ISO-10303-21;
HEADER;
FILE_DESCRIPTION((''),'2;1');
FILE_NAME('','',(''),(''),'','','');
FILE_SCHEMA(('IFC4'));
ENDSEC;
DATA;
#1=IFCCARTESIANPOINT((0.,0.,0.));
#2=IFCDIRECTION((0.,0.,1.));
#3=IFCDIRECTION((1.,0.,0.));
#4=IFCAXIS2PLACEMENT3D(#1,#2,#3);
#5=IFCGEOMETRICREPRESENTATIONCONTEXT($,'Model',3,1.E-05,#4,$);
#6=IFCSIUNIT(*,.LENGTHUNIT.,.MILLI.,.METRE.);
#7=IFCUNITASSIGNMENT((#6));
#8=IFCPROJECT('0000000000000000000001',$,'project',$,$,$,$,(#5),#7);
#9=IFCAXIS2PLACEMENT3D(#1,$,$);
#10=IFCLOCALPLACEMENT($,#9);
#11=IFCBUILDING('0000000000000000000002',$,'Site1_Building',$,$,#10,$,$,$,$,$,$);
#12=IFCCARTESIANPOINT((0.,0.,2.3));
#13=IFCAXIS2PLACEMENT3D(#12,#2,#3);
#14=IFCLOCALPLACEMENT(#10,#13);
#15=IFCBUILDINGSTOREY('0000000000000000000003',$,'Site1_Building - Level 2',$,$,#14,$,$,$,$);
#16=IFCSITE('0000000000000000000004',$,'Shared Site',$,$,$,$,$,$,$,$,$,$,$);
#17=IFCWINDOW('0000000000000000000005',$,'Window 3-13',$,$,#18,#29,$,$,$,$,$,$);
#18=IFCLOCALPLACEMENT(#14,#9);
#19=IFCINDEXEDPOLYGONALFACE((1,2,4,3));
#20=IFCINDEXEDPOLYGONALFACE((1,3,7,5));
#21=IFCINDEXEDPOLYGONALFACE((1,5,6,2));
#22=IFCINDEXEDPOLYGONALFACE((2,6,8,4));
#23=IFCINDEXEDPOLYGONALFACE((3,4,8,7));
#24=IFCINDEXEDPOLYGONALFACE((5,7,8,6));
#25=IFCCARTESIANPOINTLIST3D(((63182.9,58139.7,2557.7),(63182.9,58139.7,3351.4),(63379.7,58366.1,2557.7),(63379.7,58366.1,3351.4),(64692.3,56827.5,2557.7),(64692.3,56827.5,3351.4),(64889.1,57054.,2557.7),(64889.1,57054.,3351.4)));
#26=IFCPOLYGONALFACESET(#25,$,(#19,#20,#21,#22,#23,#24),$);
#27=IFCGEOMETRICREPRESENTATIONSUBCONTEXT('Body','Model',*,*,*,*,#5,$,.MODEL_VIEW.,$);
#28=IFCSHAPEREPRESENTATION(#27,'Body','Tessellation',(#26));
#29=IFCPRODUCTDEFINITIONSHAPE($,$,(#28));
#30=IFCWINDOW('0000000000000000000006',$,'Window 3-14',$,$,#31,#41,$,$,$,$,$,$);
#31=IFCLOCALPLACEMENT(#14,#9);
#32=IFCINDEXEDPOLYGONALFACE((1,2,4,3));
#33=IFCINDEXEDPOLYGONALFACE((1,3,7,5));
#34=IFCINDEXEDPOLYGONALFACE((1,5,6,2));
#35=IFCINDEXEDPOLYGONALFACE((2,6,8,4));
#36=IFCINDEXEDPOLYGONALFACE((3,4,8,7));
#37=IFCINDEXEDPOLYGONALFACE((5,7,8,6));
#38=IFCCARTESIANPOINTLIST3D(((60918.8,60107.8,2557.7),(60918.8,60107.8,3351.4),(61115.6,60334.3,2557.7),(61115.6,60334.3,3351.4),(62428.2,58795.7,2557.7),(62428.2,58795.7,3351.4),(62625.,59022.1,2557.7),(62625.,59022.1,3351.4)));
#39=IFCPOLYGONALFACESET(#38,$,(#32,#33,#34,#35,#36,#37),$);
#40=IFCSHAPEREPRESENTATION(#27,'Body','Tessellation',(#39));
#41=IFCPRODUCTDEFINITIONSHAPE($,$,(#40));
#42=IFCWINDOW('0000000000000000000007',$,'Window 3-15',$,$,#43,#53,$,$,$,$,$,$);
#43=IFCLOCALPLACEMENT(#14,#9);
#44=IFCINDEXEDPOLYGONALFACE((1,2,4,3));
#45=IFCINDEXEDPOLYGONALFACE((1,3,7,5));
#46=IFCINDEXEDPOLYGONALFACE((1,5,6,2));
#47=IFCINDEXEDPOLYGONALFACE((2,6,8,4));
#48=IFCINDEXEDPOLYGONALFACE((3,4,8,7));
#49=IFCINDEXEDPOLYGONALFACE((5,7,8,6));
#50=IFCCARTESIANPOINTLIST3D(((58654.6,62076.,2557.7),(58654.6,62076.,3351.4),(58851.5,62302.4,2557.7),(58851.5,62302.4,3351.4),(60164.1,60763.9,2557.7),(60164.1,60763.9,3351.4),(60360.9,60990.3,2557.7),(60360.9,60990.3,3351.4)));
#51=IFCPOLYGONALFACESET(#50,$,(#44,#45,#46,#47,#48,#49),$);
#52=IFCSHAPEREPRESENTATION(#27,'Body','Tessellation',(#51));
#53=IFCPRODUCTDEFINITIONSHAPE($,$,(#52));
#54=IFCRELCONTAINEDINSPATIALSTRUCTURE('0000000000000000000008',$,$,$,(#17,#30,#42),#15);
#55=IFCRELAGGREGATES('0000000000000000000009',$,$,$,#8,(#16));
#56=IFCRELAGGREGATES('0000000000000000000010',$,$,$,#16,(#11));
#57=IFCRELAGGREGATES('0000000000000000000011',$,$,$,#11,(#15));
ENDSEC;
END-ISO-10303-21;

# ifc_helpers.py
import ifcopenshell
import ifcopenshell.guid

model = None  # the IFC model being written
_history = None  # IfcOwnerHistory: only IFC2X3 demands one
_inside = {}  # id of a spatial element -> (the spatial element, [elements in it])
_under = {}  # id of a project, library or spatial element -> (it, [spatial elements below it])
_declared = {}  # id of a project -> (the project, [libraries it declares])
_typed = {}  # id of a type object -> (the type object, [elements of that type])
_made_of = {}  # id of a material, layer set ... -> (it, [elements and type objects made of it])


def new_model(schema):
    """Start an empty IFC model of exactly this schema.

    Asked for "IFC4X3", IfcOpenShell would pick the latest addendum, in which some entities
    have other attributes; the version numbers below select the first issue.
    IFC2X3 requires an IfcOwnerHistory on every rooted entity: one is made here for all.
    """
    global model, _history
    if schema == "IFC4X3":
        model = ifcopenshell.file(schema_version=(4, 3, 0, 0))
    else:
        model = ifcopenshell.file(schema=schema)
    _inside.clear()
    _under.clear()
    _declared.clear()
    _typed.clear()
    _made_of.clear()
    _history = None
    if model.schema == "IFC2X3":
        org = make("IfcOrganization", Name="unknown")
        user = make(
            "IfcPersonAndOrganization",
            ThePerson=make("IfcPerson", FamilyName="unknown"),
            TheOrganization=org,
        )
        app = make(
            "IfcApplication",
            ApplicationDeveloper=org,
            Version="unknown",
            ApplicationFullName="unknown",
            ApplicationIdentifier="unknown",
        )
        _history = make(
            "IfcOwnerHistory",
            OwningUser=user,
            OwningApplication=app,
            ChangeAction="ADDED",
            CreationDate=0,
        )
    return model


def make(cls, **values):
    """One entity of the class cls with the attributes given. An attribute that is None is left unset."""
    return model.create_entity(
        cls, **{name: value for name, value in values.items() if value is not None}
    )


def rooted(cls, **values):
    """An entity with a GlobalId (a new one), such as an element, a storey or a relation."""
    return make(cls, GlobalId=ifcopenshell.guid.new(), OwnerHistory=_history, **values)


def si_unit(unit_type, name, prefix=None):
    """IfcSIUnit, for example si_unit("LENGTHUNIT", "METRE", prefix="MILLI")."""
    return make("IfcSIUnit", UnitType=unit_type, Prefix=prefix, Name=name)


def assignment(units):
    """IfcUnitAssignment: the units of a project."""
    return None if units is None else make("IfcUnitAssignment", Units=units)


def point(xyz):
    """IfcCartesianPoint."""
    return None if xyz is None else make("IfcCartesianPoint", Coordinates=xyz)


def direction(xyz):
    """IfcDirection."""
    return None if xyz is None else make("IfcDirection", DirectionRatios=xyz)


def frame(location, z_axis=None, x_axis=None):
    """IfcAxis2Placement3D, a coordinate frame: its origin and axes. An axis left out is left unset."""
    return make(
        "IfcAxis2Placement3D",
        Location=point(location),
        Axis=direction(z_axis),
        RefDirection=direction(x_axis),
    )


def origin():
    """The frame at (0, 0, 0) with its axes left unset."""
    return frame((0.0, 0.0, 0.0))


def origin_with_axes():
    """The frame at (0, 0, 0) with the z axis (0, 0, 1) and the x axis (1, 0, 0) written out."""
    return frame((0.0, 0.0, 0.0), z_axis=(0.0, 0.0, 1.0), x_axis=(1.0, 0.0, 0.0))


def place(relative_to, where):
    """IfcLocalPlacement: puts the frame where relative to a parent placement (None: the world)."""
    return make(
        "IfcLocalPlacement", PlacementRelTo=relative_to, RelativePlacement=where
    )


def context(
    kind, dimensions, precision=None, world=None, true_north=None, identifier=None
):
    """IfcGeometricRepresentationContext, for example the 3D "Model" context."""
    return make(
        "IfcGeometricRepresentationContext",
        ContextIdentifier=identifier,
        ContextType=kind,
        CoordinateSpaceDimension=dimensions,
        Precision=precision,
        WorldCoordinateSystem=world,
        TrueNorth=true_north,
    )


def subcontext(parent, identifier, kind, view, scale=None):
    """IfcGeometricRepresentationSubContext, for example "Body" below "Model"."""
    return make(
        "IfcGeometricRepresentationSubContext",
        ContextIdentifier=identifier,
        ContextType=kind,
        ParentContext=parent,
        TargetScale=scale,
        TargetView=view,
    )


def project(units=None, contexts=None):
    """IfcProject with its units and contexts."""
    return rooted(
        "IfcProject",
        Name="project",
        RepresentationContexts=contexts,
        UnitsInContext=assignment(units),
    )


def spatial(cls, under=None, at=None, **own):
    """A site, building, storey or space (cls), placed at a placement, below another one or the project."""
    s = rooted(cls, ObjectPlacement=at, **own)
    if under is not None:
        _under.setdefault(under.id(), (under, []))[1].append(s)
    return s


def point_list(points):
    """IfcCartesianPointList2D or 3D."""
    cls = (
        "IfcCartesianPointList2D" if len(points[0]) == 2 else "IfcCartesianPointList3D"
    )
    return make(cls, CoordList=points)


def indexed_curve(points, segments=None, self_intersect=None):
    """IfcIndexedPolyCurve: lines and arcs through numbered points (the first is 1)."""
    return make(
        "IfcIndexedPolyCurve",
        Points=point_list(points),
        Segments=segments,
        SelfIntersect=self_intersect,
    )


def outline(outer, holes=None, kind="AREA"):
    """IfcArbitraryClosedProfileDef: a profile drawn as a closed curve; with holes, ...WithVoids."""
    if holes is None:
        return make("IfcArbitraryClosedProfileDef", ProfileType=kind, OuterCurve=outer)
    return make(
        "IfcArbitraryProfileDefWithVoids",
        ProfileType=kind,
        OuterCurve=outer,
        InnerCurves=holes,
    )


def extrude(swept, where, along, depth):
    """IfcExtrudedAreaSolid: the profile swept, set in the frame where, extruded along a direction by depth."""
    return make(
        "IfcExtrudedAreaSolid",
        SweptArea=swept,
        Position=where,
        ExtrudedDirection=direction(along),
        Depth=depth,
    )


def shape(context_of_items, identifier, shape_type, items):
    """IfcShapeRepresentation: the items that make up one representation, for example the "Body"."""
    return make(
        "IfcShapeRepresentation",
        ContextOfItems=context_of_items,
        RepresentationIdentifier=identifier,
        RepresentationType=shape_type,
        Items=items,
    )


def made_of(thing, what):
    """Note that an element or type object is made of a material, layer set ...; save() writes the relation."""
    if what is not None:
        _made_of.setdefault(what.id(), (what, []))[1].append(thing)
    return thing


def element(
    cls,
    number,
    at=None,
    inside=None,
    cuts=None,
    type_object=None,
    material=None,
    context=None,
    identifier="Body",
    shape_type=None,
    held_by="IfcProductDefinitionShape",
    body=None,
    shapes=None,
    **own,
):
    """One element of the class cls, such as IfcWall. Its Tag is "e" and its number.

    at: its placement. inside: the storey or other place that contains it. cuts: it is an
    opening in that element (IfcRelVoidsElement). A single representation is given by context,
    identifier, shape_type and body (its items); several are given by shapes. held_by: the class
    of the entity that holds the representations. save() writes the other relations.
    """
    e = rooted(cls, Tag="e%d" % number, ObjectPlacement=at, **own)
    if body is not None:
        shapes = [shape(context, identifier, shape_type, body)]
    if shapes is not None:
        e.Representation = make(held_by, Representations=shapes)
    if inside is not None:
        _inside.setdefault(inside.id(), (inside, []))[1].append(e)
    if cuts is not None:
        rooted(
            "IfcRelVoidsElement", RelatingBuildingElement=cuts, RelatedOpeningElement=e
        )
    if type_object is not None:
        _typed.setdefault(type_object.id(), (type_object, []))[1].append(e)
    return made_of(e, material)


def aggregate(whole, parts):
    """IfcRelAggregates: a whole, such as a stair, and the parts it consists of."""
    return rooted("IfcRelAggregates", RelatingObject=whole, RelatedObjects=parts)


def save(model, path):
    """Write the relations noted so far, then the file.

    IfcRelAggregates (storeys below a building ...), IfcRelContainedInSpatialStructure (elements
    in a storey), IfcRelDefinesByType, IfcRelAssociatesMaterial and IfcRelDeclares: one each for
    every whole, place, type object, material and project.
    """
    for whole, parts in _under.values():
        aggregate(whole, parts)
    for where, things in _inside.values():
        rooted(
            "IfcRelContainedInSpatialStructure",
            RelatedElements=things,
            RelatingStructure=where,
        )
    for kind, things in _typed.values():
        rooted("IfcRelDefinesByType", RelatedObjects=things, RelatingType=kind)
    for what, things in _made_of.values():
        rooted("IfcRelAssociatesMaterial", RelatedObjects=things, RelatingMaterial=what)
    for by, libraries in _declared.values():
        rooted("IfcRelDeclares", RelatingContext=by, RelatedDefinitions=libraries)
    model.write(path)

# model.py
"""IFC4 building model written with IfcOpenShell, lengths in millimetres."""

from ifc_helpers import new_model, si_unit, frame, origin, origin_with_axes, place, context, subcontext, project, spatial, indexed_curve, outline, extrude, element, save


model = new_model("IFC4")

# Units and contexts
model_context = context("Model", 3, precision=1e-05, world=origin_with_axes())
body_context = subcontext(model_context, "Body", "Model", "MODEL_VIEW")
ifc_project = project(units=[si_unit("LENGTHUNIT", "METRE", prefix="MILLI")], contexts=[model_context])

# Site, building, storey
site = spatial("IfcSite", under=ifc_project, Name="Shared Site")
building_placement = place(None, origin())
building = spatial("IfcBuilding", under=site, at=building_placement, Name="Site1_Building")
storey_placement = place(building_placement, frame((0.0, 0.0, 2.3), z_axis=(0.0, 0.0, 1.0), x_axis=(1.0, 0.0, 0.0)))
storey = spatial("IfcBuildingStorey", under=building, at=storey_placement, Name="Site1_Building - Level 2")

# Windows
for number, where, z_axis, x_axis, name in (
    (1, (64889.1, 57054.0, 2557.7), (0.0, 0.0, 1.0), (-0.75471, 0.656059, 0.0), "Window 3-13"),
    (2, (62625.0, 59022.1, 2557.7), (0.0, 0.0, 1.0), (-0.75471, 0.656059, 0.0), "Window 3-14"),
    (3, (60360.9, 60990.3, 2557.7), (0.0, 0.0, 1.0), (-0.75471, 0.656059, 0.0), "Window 3-15"),
):
    element("IfcWindow", number, at=place(storey_placement, frame(where, z_axis=z_axis, x_axis=x_axis)), inside=storey, Name=name, context=body_context, shape_type="SweptSolid", body=[
        extrude(outline(indexed_curve([(0.0, 0.0), (0.0, 300.0), (2000.0, 300.0), (2000.0, 0.0), (0.0, 0.0)], self_intersect=False)), origin_with_axes(), (0.0, 0.0, 1.0), 793.6),
    ])

save(model, "model.ifc")
